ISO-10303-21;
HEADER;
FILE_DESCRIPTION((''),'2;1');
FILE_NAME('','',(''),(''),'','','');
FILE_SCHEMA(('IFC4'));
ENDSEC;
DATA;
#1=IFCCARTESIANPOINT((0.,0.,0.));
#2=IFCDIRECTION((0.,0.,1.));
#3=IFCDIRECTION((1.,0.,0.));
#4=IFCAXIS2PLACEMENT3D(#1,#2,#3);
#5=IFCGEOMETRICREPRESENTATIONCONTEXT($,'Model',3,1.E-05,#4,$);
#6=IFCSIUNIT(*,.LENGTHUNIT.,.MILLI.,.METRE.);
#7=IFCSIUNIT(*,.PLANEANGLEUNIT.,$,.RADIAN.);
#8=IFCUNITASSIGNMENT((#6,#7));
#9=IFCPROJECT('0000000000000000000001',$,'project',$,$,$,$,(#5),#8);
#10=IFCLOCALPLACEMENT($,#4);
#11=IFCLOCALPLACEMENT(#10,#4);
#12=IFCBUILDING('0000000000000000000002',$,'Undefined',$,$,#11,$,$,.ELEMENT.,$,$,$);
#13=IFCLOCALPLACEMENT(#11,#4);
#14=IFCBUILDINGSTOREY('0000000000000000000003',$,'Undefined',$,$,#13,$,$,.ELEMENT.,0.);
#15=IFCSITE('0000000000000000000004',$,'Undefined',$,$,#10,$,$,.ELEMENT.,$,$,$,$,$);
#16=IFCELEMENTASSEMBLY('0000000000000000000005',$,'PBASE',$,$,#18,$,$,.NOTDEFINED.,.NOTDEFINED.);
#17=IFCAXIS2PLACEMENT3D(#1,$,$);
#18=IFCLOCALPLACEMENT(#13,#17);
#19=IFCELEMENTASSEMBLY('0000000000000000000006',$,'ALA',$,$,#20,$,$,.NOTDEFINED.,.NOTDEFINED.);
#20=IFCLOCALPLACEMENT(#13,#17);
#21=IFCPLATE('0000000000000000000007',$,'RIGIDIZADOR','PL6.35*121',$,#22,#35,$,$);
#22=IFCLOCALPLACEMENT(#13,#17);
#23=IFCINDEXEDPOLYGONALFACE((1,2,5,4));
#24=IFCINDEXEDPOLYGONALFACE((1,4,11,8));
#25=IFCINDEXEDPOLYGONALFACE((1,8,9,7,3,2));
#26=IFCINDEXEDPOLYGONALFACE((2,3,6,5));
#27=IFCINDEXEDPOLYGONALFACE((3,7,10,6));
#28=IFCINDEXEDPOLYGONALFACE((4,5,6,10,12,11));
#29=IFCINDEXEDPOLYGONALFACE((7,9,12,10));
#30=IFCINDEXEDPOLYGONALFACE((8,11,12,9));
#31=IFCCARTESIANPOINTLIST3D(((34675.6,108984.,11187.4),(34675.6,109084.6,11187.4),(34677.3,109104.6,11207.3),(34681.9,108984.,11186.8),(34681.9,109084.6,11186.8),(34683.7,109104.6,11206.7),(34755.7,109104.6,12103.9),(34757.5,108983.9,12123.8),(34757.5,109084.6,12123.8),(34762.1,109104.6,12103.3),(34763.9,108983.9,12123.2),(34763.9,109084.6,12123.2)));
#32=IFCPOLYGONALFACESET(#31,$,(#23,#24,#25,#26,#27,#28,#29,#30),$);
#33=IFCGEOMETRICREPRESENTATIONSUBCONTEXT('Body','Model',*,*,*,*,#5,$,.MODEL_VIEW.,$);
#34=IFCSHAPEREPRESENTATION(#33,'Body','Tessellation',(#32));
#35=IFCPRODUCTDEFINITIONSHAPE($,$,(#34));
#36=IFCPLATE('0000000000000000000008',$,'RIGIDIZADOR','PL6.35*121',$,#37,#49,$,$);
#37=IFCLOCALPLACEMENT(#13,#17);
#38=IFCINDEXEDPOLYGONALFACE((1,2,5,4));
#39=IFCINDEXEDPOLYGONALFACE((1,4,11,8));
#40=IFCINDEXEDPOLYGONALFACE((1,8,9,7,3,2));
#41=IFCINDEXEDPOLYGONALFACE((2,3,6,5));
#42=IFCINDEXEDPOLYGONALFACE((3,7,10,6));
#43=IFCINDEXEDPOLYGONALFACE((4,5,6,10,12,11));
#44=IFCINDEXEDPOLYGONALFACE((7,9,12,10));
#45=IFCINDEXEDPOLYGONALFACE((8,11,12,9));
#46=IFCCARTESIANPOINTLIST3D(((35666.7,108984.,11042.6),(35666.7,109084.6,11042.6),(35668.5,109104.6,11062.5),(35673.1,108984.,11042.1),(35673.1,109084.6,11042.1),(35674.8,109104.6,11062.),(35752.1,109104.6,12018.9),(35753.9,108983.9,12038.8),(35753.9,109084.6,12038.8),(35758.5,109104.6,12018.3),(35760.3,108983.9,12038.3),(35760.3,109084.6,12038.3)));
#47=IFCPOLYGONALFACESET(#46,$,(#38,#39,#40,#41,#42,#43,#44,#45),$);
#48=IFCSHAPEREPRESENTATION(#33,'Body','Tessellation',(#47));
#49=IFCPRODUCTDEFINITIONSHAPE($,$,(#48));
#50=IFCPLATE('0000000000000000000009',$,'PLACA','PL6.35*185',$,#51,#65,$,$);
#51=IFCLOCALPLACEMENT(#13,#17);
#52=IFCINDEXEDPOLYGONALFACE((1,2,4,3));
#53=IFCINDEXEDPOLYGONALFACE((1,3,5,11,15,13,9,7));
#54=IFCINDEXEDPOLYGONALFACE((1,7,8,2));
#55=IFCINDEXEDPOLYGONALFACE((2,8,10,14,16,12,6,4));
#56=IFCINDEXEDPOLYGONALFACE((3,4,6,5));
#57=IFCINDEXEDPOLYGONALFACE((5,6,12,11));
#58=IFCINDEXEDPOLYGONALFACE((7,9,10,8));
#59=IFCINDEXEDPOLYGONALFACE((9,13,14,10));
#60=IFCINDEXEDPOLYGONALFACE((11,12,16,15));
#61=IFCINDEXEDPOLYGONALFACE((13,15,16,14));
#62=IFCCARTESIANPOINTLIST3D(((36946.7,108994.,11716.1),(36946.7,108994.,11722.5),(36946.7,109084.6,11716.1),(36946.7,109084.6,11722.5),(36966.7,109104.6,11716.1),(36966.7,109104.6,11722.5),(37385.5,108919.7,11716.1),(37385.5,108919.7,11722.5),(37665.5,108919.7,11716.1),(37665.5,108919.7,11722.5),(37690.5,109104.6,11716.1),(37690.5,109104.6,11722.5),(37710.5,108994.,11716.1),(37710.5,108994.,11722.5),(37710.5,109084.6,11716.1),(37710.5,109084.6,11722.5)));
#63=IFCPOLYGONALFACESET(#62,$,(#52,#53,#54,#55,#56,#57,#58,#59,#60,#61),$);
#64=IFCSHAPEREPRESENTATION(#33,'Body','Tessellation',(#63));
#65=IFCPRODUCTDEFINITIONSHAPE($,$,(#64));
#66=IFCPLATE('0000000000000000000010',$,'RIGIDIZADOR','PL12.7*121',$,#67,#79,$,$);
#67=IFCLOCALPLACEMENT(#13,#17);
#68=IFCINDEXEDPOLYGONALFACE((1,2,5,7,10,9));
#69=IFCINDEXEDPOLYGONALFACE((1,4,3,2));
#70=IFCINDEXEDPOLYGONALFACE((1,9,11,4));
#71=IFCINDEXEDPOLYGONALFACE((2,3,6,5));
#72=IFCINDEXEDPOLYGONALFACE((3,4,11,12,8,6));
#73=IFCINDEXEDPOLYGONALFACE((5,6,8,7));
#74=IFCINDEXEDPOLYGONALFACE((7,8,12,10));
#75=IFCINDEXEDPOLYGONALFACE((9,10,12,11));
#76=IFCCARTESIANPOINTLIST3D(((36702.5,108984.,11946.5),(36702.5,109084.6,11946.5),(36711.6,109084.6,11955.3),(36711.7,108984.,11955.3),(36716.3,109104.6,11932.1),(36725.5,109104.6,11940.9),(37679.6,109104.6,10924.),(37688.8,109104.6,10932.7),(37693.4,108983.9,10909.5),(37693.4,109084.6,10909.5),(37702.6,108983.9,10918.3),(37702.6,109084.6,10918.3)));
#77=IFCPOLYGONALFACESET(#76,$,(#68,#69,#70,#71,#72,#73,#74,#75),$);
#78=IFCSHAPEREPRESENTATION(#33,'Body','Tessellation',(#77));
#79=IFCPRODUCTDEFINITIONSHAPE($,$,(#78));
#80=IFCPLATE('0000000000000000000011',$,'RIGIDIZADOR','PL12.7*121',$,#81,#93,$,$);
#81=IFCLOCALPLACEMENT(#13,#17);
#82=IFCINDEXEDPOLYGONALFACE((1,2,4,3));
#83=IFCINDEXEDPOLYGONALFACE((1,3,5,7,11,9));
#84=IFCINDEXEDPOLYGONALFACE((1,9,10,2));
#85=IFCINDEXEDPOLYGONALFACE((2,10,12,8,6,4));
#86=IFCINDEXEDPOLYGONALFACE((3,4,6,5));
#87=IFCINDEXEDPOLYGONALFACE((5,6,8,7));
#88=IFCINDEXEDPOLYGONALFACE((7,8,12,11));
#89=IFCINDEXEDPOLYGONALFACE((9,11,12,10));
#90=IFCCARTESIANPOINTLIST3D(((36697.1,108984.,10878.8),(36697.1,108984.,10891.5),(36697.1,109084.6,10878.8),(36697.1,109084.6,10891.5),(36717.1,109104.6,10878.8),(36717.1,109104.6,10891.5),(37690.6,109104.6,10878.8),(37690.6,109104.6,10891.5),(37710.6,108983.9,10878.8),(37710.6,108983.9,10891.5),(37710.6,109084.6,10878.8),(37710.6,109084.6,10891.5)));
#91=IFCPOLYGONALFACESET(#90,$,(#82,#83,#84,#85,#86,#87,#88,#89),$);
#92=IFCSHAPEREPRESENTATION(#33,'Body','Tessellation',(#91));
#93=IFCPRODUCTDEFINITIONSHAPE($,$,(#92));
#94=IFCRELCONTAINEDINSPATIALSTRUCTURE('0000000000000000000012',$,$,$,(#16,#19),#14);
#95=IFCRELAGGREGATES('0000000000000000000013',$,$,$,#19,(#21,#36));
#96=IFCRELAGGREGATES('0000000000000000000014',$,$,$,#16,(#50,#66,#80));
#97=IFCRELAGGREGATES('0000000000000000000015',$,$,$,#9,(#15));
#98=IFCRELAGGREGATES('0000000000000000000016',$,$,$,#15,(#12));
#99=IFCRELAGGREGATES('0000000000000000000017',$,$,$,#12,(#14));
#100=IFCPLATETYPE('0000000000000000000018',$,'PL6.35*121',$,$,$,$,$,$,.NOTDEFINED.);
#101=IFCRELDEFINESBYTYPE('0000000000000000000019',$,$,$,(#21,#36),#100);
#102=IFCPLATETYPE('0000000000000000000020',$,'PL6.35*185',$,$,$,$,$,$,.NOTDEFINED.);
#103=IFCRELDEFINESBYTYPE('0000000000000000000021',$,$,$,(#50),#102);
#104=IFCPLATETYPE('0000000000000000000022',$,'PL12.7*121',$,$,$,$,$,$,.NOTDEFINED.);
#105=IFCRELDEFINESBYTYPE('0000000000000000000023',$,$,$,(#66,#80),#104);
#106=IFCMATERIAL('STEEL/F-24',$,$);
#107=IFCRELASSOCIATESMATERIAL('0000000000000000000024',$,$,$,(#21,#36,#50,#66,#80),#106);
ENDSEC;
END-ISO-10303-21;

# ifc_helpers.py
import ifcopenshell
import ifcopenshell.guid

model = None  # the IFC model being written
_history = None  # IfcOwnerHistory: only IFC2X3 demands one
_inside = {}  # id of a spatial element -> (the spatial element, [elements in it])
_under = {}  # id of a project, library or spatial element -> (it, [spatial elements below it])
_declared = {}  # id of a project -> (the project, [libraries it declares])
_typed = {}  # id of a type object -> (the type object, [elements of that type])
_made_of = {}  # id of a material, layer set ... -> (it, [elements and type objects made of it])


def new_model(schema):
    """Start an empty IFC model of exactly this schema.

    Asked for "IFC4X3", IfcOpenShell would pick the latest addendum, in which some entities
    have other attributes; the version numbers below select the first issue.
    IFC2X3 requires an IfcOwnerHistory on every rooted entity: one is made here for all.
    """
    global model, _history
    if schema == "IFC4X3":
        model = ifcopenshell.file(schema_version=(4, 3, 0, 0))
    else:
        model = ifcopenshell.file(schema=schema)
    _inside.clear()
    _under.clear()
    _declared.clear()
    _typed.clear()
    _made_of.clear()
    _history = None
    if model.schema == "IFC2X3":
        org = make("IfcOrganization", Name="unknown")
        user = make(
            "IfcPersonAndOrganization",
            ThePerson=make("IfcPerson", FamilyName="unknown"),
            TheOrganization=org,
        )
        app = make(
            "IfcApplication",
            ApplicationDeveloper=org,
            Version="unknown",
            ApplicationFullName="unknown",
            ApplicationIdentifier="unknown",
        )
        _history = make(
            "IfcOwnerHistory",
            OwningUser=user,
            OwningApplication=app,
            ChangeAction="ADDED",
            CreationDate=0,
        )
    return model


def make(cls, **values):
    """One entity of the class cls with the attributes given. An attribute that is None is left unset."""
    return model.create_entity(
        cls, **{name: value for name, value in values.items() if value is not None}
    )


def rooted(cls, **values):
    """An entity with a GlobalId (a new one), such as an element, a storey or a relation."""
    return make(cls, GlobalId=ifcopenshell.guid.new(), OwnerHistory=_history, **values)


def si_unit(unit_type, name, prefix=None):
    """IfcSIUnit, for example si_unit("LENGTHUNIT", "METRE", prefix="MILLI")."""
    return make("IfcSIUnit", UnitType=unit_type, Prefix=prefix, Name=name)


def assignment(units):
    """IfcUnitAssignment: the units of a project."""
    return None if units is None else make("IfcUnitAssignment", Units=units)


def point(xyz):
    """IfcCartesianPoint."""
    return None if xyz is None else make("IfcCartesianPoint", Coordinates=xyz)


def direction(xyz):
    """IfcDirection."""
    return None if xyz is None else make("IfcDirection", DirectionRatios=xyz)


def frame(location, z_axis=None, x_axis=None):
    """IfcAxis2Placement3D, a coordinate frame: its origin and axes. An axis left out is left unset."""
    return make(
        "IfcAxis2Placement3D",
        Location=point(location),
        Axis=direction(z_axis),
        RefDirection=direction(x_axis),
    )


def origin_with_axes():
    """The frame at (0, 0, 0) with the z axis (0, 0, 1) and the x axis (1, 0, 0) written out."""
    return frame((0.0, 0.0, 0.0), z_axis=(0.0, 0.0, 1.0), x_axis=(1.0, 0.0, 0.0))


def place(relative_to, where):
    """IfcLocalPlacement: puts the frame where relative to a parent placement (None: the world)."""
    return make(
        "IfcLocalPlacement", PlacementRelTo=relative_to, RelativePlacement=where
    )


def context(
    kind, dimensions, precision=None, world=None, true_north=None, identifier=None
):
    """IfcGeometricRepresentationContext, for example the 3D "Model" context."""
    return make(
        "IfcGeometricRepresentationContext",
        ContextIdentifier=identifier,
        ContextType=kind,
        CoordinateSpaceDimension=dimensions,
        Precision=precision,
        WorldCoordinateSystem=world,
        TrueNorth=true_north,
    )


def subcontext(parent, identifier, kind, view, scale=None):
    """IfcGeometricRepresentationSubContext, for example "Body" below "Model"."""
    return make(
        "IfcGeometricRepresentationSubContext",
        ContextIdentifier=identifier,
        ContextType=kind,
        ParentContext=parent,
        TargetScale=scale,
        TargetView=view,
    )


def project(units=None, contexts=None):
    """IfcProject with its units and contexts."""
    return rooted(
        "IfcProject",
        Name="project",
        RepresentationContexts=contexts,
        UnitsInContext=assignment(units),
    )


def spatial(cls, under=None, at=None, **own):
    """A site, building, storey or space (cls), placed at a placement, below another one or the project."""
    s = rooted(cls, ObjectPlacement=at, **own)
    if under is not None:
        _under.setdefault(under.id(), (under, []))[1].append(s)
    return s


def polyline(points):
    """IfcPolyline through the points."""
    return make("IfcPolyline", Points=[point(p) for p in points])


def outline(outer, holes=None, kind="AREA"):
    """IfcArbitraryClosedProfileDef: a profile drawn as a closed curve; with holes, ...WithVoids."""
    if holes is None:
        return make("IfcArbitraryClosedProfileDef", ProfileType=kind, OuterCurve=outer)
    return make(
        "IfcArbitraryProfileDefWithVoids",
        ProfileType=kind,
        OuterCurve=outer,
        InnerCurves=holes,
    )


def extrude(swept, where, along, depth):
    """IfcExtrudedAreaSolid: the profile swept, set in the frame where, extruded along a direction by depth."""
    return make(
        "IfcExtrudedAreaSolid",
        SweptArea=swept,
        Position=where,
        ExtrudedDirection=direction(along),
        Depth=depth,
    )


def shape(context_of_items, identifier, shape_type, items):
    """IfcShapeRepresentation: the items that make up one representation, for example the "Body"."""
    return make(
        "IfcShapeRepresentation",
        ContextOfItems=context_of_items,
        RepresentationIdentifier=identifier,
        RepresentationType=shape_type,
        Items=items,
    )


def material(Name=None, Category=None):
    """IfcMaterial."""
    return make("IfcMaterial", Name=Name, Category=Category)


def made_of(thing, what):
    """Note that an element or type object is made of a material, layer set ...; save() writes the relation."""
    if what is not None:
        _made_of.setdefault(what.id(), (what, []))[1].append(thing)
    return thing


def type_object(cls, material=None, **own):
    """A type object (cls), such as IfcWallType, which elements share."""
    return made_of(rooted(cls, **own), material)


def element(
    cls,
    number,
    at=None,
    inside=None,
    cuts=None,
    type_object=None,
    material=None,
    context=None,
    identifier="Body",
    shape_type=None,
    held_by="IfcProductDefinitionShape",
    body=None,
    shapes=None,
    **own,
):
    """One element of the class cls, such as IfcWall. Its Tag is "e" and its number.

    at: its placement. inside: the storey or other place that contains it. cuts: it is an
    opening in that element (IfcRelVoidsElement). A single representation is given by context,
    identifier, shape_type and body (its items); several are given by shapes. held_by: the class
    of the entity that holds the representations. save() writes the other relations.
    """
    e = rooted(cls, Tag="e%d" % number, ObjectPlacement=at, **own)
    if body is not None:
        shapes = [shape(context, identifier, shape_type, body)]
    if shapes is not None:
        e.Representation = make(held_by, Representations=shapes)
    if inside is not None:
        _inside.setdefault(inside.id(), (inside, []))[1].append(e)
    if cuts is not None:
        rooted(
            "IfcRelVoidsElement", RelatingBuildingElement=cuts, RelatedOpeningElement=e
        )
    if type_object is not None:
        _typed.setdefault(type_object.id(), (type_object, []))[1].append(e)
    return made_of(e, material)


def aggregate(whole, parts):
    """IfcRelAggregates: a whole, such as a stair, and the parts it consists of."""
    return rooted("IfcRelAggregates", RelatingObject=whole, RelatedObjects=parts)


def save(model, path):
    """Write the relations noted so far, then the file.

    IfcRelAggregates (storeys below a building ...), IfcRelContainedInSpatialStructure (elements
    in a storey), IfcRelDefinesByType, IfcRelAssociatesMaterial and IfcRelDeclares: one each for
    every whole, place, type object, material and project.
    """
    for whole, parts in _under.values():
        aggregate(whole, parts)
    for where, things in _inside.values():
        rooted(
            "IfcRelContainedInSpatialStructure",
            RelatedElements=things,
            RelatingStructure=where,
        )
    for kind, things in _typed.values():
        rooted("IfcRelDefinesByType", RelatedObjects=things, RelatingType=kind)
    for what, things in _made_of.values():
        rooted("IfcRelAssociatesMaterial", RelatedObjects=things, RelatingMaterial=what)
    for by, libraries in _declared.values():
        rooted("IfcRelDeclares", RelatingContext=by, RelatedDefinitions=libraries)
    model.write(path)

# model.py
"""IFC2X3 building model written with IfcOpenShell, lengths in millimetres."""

from ifc_helpers import new_model, si_unit, frame, origin_with_axes, place, context, subcontext, project, spatial, polyline, outline, extrude, material, type_object, element, aggregate, save


model = new_model("IFC2X3")

# Units and contexts
model_context = context("Model", 3, precision=1e-05, world=origin_with_axes())
body_context = subcontext(model_context, "Body", "Model", "MODEL_VIEW")
ifc_project = project(units=[si_unit("LENGTHUNIT", "METRE", prefix="MILLI"), si_unit("PLANEANGLEUNIT", "RADIAN")], contexts=[model_context])

# Site, building, storey
site_placement = place(None, origin_with_axes())
site = spatial("IfcSite", under=ifc_project, at=site_placement, Name="Undefined", CompositionType="ELEMENT")
building_placement = place(site_placement, origin_with_axes())
building = spatial("IfcBuilding", under=site, at=building_placement, Name="Undefined", CompositionType="ELEMENT")
storey_placement = place(building_placement, origin_with_axes())
storey = spatial("IfcBuildingStorey", under=building, at=storey_placement, Name="Undefined", CompositionType="ELEMENT", Elevation=0.0)

# Element assembly
ifc_material_1 = material(Name="STEEL/F-24")
assembly_1_placement = place(storey_placement, origin_with_axes())
assembly_1 = element("IfcElementAssembly", 1, at=assembly_1_placement, inside=storey, Name="PBASE", AssemblyPlace="NOTDEFINED", PredefinedType="NOTDEFINED")

# Element assembly
assembly_2_placement = place(storey_placement, origin_with_axes())
assembly_2 = element("IfcElementAssembly", 2, at=assembly_2_placement, inside=storey, Name="ALA", AssemblyPlace="NOTDEFINED", PredefinedType="NOTDEFINED")

# Plates
plate_type_1 = type_object("IfcPlateType", Name="PL6.35*121", PredefinedType="NOTDEFINED")
plate_1_placement = place(assembly_2_placement, frame((34760.7, 109104.6, 12123.5), z_axis=(0.996195, 0.0, -0.087155), x_axis=(0.0, -1.0, 0.0)))
plate_1 = element("IfcPlate", 3, at=plate_1_placement, type_object=plate_type_1, material=ifc_material_1, Name="RIGIDIZADOR", Description="PL6.35*121", context=body_context, shape_type="SweptSolid", body=[
    extrude(outline(polyline([(0.0, 20.0), (20.0, 0.0), (120.6, 0.0), (120.6, 940.0), (20.0, 940.0), (0.0, 920.0), (0.0, 20.0)])), frame((0.0, 0.0, -3.2), z_axis=(0.0, 0.0, 1.0), x_axis=(1.0, 0.0, 0.0)), (0.0, 0.0, 1.0), 6.4),
])
plate_2_placement = place(assembly_2_placement, frame((35757.1, 109104.6, 12038.5), z_axis=(0.996195, 0.0, -0.087155), x_axis=(0.0, -1.0, 0.0)))
plate_2 = element("IfcPlate", 4, at=plate_2_placement, type_object=plate_type_1, material=ifc_material_1, Name="RIGIDIZADOR", Description="PL6.35*121", context=body_context, shape_type="SweptSolid", body=[
    extrude(outline(polyline([(0.0, 20.0), (20.0, 0.0), (120.6, 0.0), (120.6, 1000.0), (20.0, 1000.0), (0.0, 980.0), (0.0, 20.0)])), frame((0.0, 0.0, -3.2), z_axis=(0.0, 0.0, 1.0), x_axis=(1.0, 0.0, 0.0)), (0.0, 0.0, 1.0), 6.4),
])
aggregate(assembly_2, [plate_1, plate_2])
plate_type_2 = type_object("IfcPlateType", Name="PL6.35*185", PredefinedType="NOTDEFINED")
plate_3_placement = place(assembly_1_placement, frame((37710.5, 108994.0, 11719.3), z_axis=(0.000012, 0.0, 1.0), x_axis=(0.0, 1.0, 0.0)))
plate_3 = element("IfcPlate", 5, at=plate_3_placement, type_object=plate_type_2, material=ifc_material_1, Name="PLACA", Description="PL6.35*185", context=body_context, shape_type="SweptSolid", body=[
    extrude(outline(polyline([(0.0, 0.0), (90.6, 0.0), (110.6, 20.0), (110.6, 743.9), (90.6, 763.9), (0.0, 763.9), (-74.3, 325.0), (-74.3, 45.0), (0.0, 0.0)])), frame((0.0, 0.0, -3.2), z_axis=(0.0, 0.0, 1.0), x_axis=(1.0, 0.0, 0.0)), (0.0, 0.0, 1.0), 6.4),
])
plate_type_3 = type_object("IfcPlateType", Name="PL12.7*121", PredefinedType="NOTDEFINED")
plate_4_placement = place(assembly_1_placement, frame((37698.0, 109104.6, 10913.9), z_axis=(-0.722988, 0.0, -0.69086), x_axis=(0.0, -1.0, 0.0)))
plate_4 = element("IfcPlate", 6, at=plate_4_placement, type_object=plate_type_3, material=ifc_material_1, Name="RIGIDIZADOR", Description="PL12.7*121", context=body_context, shape_type="SweptSolid", body=[
    extrude(outline(polyline([(0.0, 20.0), (20.0, 0.0), (120.6, 0.0), (120.6, 1434.4), (20.0, 1434.4), (0.0, 1414.4), (0.0, 20.0)])), frame((0.0, 0.0, -6.3), z_axis=(0.0, 0.0, 1.0), x_axis=(1.0, 0.0, 0.0)), (0.0, 0.0, 1.0), 12.7),
])
plate_5_placement = place(assembly_1_placement, frame((37710.6, 109104.6, 10885.1), z_axis=(0.0, 0.0, -1.0), x_axis=(0.0, -1.0, 0.0)))
plate_5 = element("IfcPlate", 7, at=plate_5_placement, type_object=plate_type_3, material=ifc_material_1, Name="RIGIDIZADOR", Description="PL12.7*121", context=body_context, shape_type="SweptSolid", body=[
    extrude(outline(polyline([(0.0, 20.0), (20.0, 0.0), (120.6, 0.0), (120.6, 1013.5), (20.0, 1013.5), (0.0, 993.5), (0.0, 20.0)])), frame((0.0, 0.0, -6.3), z_axis=(0.0, 0.0, 1.0), x_axis=(1.0, 0.0, 0.0)), (0.0, 0.0, 1.0), 12.7),
])

aggregate(assembly_1, [plate_3, plate_4, plate_5])

save(model, "model.ifc")
